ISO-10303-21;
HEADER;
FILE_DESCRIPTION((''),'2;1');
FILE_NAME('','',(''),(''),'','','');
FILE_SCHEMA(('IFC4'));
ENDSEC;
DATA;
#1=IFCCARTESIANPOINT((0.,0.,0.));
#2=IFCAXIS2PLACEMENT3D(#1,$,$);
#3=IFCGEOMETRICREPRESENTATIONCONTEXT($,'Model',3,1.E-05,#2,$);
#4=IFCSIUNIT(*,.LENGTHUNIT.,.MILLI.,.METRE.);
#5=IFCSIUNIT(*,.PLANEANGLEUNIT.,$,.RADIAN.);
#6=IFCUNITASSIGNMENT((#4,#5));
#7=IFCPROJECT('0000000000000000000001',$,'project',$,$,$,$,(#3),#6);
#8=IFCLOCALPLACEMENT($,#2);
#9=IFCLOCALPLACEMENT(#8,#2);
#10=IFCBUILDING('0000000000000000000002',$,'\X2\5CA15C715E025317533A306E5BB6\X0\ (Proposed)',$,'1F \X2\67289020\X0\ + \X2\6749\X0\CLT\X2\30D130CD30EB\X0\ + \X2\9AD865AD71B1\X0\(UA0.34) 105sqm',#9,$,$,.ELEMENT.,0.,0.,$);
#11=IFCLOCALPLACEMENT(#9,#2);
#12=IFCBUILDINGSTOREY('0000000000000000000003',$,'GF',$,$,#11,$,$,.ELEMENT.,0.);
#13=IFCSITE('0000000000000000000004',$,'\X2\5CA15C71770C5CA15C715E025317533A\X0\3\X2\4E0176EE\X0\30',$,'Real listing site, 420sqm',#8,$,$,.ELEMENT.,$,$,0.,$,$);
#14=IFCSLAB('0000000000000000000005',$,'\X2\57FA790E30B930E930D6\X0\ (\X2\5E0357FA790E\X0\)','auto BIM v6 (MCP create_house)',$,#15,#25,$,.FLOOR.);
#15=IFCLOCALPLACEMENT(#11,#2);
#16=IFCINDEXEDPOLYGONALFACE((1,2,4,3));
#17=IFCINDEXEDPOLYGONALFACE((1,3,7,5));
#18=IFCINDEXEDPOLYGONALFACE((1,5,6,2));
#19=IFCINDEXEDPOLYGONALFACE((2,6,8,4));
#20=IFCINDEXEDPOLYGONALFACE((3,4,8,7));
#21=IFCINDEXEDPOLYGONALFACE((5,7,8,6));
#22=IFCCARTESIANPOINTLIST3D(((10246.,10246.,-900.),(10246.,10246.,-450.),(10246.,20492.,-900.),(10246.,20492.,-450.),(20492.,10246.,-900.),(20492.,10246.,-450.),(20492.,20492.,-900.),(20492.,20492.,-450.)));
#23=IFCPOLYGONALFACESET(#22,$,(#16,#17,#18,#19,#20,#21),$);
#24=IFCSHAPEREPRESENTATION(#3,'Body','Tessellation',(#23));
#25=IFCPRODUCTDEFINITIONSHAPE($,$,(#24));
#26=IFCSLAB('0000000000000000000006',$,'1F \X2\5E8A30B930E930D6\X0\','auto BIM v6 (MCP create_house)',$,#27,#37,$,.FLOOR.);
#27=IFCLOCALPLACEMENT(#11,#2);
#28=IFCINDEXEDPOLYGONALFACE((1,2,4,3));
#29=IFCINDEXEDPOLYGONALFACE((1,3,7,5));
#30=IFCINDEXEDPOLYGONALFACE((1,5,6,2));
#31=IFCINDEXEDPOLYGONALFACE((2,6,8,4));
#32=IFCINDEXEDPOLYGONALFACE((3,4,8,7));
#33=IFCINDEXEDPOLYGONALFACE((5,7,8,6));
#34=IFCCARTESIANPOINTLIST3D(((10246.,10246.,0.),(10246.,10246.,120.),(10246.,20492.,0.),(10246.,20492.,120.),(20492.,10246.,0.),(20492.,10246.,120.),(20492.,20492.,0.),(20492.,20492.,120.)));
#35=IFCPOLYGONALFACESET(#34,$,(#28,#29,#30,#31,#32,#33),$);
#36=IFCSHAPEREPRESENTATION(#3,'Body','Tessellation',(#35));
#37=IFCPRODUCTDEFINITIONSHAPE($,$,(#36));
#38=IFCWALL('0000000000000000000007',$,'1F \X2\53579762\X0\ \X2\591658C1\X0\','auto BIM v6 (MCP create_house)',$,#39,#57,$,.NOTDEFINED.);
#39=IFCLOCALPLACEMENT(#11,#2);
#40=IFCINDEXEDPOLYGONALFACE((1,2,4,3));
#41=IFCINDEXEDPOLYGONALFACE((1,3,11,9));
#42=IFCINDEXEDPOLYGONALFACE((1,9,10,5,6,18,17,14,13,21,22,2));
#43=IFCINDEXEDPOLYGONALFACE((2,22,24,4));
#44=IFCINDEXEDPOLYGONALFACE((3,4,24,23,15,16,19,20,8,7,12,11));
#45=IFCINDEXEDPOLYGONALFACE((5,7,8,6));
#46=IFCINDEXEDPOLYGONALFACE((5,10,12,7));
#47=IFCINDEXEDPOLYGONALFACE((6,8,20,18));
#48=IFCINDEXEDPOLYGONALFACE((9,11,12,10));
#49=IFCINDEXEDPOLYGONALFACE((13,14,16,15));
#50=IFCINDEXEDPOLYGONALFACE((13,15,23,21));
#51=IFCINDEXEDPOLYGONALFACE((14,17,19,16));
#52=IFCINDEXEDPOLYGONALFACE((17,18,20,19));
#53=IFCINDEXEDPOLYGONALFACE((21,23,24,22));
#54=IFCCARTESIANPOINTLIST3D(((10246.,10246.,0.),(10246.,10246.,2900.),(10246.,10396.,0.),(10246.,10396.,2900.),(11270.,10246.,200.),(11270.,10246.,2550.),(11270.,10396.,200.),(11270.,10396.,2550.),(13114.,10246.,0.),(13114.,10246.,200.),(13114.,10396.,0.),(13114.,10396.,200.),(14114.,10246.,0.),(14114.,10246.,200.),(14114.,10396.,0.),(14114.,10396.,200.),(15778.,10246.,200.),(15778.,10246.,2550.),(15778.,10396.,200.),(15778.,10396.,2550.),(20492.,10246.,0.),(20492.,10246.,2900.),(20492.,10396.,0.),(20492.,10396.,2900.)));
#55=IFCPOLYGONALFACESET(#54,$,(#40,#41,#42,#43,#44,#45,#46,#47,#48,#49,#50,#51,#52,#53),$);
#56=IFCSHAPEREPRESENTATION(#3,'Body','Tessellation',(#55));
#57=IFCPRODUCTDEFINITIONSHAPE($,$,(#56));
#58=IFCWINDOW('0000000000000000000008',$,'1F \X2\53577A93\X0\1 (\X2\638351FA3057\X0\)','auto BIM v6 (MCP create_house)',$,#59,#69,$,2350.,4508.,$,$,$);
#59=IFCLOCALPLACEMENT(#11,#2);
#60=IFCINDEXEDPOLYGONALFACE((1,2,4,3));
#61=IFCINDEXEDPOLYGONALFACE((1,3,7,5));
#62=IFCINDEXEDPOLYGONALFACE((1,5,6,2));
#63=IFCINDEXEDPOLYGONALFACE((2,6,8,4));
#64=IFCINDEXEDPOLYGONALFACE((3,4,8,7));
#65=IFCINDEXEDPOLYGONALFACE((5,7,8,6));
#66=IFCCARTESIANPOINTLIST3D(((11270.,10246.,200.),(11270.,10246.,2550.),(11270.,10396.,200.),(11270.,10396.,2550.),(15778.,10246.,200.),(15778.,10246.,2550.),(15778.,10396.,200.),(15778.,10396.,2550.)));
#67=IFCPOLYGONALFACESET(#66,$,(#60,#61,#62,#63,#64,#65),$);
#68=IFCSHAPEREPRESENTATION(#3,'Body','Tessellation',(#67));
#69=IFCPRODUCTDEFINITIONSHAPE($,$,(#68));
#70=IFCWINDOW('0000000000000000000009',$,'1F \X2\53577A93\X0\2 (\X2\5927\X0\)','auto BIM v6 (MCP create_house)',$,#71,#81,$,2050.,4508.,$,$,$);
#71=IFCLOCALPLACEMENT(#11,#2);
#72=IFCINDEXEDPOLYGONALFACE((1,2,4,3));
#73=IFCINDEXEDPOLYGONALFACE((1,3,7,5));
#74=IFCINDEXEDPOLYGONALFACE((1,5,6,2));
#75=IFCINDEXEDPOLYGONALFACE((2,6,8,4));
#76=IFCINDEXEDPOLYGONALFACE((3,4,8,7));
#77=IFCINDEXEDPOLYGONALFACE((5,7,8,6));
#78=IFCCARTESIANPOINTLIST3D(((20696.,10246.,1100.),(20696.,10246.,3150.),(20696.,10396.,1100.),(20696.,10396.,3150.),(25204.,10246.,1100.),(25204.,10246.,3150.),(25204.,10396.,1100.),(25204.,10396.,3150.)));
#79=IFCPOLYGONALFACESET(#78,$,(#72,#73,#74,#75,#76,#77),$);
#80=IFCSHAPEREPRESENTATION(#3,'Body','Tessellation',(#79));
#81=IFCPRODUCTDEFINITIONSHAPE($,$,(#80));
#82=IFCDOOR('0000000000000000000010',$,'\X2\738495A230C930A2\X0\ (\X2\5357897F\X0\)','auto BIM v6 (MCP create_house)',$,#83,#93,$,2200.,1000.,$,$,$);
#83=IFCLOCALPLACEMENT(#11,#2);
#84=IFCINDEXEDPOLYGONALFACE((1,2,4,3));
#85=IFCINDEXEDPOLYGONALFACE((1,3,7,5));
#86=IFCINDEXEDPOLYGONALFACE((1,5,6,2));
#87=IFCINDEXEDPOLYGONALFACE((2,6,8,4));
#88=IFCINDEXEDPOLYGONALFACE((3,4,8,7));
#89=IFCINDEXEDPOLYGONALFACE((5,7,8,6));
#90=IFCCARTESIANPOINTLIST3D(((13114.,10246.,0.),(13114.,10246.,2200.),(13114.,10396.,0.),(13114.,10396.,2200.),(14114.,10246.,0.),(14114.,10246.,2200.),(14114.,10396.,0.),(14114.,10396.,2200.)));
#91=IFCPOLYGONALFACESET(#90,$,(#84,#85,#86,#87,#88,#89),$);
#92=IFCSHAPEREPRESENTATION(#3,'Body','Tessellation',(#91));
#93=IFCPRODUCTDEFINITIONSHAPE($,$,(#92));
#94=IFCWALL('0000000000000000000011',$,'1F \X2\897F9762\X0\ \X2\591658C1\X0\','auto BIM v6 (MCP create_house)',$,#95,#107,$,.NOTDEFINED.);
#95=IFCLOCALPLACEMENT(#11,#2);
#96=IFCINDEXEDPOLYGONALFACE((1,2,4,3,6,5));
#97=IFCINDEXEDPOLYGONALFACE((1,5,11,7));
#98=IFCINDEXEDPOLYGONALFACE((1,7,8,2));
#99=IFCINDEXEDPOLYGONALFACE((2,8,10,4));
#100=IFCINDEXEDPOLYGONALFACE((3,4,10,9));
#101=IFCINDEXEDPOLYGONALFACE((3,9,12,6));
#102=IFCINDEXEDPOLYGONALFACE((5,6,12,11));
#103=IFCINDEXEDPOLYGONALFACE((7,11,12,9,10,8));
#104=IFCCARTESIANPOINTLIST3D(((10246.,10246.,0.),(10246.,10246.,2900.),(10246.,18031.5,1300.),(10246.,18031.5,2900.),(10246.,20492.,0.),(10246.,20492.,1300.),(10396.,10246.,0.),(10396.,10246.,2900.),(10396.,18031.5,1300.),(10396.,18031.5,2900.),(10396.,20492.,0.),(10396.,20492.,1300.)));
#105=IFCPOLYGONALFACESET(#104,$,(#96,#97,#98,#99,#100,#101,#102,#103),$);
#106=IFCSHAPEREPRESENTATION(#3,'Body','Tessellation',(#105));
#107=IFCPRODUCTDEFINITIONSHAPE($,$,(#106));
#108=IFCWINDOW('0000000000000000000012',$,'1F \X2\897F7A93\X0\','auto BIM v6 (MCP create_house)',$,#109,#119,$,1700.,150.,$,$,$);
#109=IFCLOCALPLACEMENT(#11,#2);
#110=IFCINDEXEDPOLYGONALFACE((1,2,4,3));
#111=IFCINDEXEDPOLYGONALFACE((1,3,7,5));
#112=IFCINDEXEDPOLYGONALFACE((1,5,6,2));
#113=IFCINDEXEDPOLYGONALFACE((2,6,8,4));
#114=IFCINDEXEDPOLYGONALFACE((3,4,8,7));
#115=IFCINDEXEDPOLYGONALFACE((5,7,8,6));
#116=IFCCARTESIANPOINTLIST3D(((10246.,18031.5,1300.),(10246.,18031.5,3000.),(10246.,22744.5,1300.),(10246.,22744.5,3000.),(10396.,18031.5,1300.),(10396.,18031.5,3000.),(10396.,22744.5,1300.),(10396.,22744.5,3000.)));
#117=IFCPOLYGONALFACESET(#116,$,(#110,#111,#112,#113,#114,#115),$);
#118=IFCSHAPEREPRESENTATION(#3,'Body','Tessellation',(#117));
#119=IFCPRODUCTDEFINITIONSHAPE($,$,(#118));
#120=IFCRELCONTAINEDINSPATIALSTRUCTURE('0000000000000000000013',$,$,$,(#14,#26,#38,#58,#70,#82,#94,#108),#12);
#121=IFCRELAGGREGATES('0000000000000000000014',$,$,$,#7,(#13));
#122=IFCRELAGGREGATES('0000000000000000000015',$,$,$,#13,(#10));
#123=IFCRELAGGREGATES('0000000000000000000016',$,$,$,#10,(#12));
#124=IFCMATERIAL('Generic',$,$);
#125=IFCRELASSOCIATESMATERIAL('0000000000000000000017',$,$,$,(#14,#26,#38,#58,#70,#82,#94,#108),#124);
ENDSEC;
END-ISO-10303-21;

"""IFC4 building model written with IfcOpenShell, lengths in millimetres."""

from ifc_helpers import new_model, si_unit, frame, frame_2d, origin, place, context, project, spatial, rectangle, extrude, material, element, fill, save


model = new_model("IFC4")

# Units and contexts
model_context = context("Model", 3, precision=1e-05, world=origin())
ifc_project = project(units=[si_unit("LENGTHUNIT", "METRE", prefix="MILLI"), si_unit("PLANEANGLEUNIT", "RADIAN")], contexts=[model_context])

# Site, building, storey
site_placement = place(None, origin())
site = spatial("IfcSite", under=ifc_project, at=site_placement, Name="岡山県岡山市北区3丁目30", ObjectType="Real listing site, 420sqm", CompositionType="ELEMENT", RefElevation=0.0)
building_placement = place(site_placement, origin())
building = spatial("IfcBuilding", under=site, at=building_placement, Name="岡山市北区の家 (Proposed)", ObjectType="1F 木造 + 杉CLTパネル + 高断熱(UA0.34) 105sqm", CompositionType="ELEMENT", ElevationOfRefHeight=0.0, ElevationOfTerrain=0.0)
storey_placement = place(building_placement, origin())
storey = spatial("IfcBuildingStorey", under=building, at=storey_placement, Name="GF", CompositionType="ELEMENT", Elevation=0.0)

# Slabs
ifc_material = material(Name="Generic")
slab_1_placement = place(storey_placement, frame((5123.0, 5123.0, -450.0)))
element("IfcSlab", 1, at=slab_1_placement, inside=storey, material=ifc_material, Name="基礎スラブ (布基礎)", Description="auto BIM v6 (MCP create_house)", PredefinedType="FLOOR", context=model_context, shape_type="SweptSolid", body=[
    extrude(rectangle(XDim=10246.0, YDim=10246.0, at=frame_2d((5123.0, 5123.0))), frame((5123.0, 5123.0, -450.0)), (0.0, 0.0, 1.0), 450.0),
])
slab_2_placement = place(storey_placement, frame((5123.0, 5123.0, 0.0)))
element("IfcSlab", 2, at=slab_2_placement, inside=storey, material=ifc_material, Name="1F 床スラブ", Description="auto BIM v6 (MCP create_house)", PredefinedType="FLOOR", context=model_context, shape_type="SweptSolid", body=[
    extrude(rectangle(XDim=10246.0, YDim=10246.0, at=frame_2d((5123.0, 5123.0))), frame((5123.0, 5123.0, 0.0)), (0.0, 0.0, 1.0), 120.0),
])

# Wall, openings, windows, door
wall_1_placement = place(storey_placement, frame((5123.0, 5123.0, 0.0)))
wall_1 = element("IfcWall", 3, at=wall_1_placement, inside=storey, material=ifc_material, Name="1F 南面 外壁", Description="auto BIM v6 (MCP create_house)", PredefinedType="NOTDEFINED", context=model_context, shape_type="SweptSolid", body=[
    extrude(rectangle(XDim=10246.0, YDim=150.0, at=frame_2d((5123.0, 75.0))), frame((5123.0, 5123.0, 0.0)), (0.0, 0.0, 1.0), 2900.0),
])
opening_1_placement = place(storey_placement, frame((5635.0, 5123.0, 100.0)))
opening_1 = element("IfcOpeningElement", 4, at=opening_1_placement, cuts=wall_1, PredefinedType="NOTDEFINED", context=model_context, shape_type="SweptSolid", body=[
    extrude(rectangle(XDim=4508.0, YDim=150.0, at=frame_2d((2254.0, 75.0))), frame((5635.0, 5123.0, 100.0)), (0.0, 0.0, 1.0), 2350.0),
])
opening_2_placement = place(storey_placement, frame((10348.0, 5123.0, 550.0)))
opening_2 = element("IfcOpeningElement", 5, at=opening_2_placement, cuts=wall_1, PredefinedType="NOTDEFINED", context=model_context, shape_type="SweptSolid", body=[
    extrude(rectangle(XDim=4508.0, YDim=150.0, at=frame_2d((2254.0, 75.0))), frame((10348.0, 5123.0, 550.0)), (0.0, 0.0, 1.0), 2050.0),
])
opening_3_placement = place(storey_placement, frame((6557.0, 5123.0, 0.0)))
opening_3 = element("IfcOpeningElement", 6, at=opening_3_placement, cuts=wall_1, PredefinedType="NOTDEFINED", context=model_context, shape_type="SweptSolid", body=[
    extrude(rectangle(XDim=1000.0, YDim=150.0, at=frame_2d((500.0, 75.0))), frame((6557.0, 5123.0, 0.0)), (0.0, 0.0, 1.0), 2200.0),
])
window_1_placement = place(storey_placement, frame((5635.0, 5123.0, 100.0)))
window_1 = element("IfcWindow", 7, at=window_1_placement, inside=storey, material=ifc_material, Name="1F 南窓1 (掃出し)", Description="auto BIM v6 (MCP create_house)", OverallHeight=2350.0, OverallWidth=4508.0, context=model_context, shape_type="SweptSolid", body=[
    extrude(rectangle(XDim=4508.0, YDim=150.0, at=frame_2d((2254.0, 75.0))), frame((5635.0, 5123.0, 100.0)), (0.0, 0.0, 1.0), 2350.0),
])
fill(opening_1, window_1)
window_2_placement = place(storey_placement, frame((10348.0, 5123.0, 550.0)))
window_2 = element("IfcWindow", 8, at=window_2_placement, inside=storey, material=ifc_material, Name="1F 南窓2 (大)", Description="auto BIM v6 (MCP create_house)", OverallHeight=2050.0, OverallWidth=4508.0, context=model_context, shape_type="SweptSolid", body=[
    extrude(rectangle(XDim=4508.0, YDim=150.0, at=frame_2d((2254.0, 75.0))), frame((10348.0, 5123.0, 550.0)), (0.0, 0.0, 1.0), 2050.0),
])
fill(opening_2, window_2)
door_placement = place(storey_placement, frame((6557.0, 5123.0, 0.0)))
door = element("IfcDoor", 9, at=door_placement, inside=storey, material=ifc_material, Name="玄関ドア (南西)", Description="auto BIM v6 (MCP create_house)", OverallHeight=2200.0, OverallWidth=1000.0, context=model_context, shape_type="SweptSolid", body=[
    extrude(rectangle(XDim=1000.0, YDim=150.0, at=frame_2d((500.0, 75.0))), frame((6557.0, 5123.0, 0.0)), (0.0, 0.0, 1.0), 2200.0),
])
fill(opening_3, door)

# Wall, opening, window
wall_2_placement = place(storey_placement, frame((5123.0, 5123.0, 0.0)))
wall_2 = element("IfcWall", 10, at=wall_2_placement, inside=storey, material=ifc_material, Name="1F 西面 外壁", Description="auto BIM v6 (MCP create_house)", PredefinedType="NOTDEFINED", context=model_context, shape_type="SweptSolid", body=[
    extrude(rectangle(XDim=150.0, YDim=10246.0, at=frame_2d((75.0, 5123.0))), frame((5123.0, 5123.0, 0.0)), (0.0, 0.0, 1.0), 2900.0),
])
opening_4_placement = place(storey_placement, frame((5123.0, 9016.0, 650.0)))
opening_4 = element("IfcOpeningElement", 11, at=opening_4_placement, cuts=wall_2, PredefinedType="NOTDEFINED", context=model_context, shape_type="SweptSolid", body=[
    extrude(rectangle(XDim=150.0, YDim=4713.0, at=frame_2d((75.0, 2356.0))), frame((5123.0, 9016.0, 650.0)), (0.0, 0.0, 1.0), 1700.0),
])
window_3_placement = place(storey_placement, frame((5123.0, 9016.0, 650.0)))
window_3 = element("IfcWindow", 12, at=window_3_placement, inside=storey, material=ifc_material, Name="1F 西窓", Description="auto BIM v6 (MCP create_house)", OverallHeight=1700.0, OverallWidth=150.0, context=model_context, shape_type="SweptSolid", body=[
    extrude(rectangle(XDim=150.0, YDim=4713.0, at=frame_2d((75.0, 2356.0))), frame((5123.0, 9016.0, 650.0)), (0.0, 0.0, 1.0), 1700.0),
])
fill(opening_4, window_3)

save(model, "model.ifc")
